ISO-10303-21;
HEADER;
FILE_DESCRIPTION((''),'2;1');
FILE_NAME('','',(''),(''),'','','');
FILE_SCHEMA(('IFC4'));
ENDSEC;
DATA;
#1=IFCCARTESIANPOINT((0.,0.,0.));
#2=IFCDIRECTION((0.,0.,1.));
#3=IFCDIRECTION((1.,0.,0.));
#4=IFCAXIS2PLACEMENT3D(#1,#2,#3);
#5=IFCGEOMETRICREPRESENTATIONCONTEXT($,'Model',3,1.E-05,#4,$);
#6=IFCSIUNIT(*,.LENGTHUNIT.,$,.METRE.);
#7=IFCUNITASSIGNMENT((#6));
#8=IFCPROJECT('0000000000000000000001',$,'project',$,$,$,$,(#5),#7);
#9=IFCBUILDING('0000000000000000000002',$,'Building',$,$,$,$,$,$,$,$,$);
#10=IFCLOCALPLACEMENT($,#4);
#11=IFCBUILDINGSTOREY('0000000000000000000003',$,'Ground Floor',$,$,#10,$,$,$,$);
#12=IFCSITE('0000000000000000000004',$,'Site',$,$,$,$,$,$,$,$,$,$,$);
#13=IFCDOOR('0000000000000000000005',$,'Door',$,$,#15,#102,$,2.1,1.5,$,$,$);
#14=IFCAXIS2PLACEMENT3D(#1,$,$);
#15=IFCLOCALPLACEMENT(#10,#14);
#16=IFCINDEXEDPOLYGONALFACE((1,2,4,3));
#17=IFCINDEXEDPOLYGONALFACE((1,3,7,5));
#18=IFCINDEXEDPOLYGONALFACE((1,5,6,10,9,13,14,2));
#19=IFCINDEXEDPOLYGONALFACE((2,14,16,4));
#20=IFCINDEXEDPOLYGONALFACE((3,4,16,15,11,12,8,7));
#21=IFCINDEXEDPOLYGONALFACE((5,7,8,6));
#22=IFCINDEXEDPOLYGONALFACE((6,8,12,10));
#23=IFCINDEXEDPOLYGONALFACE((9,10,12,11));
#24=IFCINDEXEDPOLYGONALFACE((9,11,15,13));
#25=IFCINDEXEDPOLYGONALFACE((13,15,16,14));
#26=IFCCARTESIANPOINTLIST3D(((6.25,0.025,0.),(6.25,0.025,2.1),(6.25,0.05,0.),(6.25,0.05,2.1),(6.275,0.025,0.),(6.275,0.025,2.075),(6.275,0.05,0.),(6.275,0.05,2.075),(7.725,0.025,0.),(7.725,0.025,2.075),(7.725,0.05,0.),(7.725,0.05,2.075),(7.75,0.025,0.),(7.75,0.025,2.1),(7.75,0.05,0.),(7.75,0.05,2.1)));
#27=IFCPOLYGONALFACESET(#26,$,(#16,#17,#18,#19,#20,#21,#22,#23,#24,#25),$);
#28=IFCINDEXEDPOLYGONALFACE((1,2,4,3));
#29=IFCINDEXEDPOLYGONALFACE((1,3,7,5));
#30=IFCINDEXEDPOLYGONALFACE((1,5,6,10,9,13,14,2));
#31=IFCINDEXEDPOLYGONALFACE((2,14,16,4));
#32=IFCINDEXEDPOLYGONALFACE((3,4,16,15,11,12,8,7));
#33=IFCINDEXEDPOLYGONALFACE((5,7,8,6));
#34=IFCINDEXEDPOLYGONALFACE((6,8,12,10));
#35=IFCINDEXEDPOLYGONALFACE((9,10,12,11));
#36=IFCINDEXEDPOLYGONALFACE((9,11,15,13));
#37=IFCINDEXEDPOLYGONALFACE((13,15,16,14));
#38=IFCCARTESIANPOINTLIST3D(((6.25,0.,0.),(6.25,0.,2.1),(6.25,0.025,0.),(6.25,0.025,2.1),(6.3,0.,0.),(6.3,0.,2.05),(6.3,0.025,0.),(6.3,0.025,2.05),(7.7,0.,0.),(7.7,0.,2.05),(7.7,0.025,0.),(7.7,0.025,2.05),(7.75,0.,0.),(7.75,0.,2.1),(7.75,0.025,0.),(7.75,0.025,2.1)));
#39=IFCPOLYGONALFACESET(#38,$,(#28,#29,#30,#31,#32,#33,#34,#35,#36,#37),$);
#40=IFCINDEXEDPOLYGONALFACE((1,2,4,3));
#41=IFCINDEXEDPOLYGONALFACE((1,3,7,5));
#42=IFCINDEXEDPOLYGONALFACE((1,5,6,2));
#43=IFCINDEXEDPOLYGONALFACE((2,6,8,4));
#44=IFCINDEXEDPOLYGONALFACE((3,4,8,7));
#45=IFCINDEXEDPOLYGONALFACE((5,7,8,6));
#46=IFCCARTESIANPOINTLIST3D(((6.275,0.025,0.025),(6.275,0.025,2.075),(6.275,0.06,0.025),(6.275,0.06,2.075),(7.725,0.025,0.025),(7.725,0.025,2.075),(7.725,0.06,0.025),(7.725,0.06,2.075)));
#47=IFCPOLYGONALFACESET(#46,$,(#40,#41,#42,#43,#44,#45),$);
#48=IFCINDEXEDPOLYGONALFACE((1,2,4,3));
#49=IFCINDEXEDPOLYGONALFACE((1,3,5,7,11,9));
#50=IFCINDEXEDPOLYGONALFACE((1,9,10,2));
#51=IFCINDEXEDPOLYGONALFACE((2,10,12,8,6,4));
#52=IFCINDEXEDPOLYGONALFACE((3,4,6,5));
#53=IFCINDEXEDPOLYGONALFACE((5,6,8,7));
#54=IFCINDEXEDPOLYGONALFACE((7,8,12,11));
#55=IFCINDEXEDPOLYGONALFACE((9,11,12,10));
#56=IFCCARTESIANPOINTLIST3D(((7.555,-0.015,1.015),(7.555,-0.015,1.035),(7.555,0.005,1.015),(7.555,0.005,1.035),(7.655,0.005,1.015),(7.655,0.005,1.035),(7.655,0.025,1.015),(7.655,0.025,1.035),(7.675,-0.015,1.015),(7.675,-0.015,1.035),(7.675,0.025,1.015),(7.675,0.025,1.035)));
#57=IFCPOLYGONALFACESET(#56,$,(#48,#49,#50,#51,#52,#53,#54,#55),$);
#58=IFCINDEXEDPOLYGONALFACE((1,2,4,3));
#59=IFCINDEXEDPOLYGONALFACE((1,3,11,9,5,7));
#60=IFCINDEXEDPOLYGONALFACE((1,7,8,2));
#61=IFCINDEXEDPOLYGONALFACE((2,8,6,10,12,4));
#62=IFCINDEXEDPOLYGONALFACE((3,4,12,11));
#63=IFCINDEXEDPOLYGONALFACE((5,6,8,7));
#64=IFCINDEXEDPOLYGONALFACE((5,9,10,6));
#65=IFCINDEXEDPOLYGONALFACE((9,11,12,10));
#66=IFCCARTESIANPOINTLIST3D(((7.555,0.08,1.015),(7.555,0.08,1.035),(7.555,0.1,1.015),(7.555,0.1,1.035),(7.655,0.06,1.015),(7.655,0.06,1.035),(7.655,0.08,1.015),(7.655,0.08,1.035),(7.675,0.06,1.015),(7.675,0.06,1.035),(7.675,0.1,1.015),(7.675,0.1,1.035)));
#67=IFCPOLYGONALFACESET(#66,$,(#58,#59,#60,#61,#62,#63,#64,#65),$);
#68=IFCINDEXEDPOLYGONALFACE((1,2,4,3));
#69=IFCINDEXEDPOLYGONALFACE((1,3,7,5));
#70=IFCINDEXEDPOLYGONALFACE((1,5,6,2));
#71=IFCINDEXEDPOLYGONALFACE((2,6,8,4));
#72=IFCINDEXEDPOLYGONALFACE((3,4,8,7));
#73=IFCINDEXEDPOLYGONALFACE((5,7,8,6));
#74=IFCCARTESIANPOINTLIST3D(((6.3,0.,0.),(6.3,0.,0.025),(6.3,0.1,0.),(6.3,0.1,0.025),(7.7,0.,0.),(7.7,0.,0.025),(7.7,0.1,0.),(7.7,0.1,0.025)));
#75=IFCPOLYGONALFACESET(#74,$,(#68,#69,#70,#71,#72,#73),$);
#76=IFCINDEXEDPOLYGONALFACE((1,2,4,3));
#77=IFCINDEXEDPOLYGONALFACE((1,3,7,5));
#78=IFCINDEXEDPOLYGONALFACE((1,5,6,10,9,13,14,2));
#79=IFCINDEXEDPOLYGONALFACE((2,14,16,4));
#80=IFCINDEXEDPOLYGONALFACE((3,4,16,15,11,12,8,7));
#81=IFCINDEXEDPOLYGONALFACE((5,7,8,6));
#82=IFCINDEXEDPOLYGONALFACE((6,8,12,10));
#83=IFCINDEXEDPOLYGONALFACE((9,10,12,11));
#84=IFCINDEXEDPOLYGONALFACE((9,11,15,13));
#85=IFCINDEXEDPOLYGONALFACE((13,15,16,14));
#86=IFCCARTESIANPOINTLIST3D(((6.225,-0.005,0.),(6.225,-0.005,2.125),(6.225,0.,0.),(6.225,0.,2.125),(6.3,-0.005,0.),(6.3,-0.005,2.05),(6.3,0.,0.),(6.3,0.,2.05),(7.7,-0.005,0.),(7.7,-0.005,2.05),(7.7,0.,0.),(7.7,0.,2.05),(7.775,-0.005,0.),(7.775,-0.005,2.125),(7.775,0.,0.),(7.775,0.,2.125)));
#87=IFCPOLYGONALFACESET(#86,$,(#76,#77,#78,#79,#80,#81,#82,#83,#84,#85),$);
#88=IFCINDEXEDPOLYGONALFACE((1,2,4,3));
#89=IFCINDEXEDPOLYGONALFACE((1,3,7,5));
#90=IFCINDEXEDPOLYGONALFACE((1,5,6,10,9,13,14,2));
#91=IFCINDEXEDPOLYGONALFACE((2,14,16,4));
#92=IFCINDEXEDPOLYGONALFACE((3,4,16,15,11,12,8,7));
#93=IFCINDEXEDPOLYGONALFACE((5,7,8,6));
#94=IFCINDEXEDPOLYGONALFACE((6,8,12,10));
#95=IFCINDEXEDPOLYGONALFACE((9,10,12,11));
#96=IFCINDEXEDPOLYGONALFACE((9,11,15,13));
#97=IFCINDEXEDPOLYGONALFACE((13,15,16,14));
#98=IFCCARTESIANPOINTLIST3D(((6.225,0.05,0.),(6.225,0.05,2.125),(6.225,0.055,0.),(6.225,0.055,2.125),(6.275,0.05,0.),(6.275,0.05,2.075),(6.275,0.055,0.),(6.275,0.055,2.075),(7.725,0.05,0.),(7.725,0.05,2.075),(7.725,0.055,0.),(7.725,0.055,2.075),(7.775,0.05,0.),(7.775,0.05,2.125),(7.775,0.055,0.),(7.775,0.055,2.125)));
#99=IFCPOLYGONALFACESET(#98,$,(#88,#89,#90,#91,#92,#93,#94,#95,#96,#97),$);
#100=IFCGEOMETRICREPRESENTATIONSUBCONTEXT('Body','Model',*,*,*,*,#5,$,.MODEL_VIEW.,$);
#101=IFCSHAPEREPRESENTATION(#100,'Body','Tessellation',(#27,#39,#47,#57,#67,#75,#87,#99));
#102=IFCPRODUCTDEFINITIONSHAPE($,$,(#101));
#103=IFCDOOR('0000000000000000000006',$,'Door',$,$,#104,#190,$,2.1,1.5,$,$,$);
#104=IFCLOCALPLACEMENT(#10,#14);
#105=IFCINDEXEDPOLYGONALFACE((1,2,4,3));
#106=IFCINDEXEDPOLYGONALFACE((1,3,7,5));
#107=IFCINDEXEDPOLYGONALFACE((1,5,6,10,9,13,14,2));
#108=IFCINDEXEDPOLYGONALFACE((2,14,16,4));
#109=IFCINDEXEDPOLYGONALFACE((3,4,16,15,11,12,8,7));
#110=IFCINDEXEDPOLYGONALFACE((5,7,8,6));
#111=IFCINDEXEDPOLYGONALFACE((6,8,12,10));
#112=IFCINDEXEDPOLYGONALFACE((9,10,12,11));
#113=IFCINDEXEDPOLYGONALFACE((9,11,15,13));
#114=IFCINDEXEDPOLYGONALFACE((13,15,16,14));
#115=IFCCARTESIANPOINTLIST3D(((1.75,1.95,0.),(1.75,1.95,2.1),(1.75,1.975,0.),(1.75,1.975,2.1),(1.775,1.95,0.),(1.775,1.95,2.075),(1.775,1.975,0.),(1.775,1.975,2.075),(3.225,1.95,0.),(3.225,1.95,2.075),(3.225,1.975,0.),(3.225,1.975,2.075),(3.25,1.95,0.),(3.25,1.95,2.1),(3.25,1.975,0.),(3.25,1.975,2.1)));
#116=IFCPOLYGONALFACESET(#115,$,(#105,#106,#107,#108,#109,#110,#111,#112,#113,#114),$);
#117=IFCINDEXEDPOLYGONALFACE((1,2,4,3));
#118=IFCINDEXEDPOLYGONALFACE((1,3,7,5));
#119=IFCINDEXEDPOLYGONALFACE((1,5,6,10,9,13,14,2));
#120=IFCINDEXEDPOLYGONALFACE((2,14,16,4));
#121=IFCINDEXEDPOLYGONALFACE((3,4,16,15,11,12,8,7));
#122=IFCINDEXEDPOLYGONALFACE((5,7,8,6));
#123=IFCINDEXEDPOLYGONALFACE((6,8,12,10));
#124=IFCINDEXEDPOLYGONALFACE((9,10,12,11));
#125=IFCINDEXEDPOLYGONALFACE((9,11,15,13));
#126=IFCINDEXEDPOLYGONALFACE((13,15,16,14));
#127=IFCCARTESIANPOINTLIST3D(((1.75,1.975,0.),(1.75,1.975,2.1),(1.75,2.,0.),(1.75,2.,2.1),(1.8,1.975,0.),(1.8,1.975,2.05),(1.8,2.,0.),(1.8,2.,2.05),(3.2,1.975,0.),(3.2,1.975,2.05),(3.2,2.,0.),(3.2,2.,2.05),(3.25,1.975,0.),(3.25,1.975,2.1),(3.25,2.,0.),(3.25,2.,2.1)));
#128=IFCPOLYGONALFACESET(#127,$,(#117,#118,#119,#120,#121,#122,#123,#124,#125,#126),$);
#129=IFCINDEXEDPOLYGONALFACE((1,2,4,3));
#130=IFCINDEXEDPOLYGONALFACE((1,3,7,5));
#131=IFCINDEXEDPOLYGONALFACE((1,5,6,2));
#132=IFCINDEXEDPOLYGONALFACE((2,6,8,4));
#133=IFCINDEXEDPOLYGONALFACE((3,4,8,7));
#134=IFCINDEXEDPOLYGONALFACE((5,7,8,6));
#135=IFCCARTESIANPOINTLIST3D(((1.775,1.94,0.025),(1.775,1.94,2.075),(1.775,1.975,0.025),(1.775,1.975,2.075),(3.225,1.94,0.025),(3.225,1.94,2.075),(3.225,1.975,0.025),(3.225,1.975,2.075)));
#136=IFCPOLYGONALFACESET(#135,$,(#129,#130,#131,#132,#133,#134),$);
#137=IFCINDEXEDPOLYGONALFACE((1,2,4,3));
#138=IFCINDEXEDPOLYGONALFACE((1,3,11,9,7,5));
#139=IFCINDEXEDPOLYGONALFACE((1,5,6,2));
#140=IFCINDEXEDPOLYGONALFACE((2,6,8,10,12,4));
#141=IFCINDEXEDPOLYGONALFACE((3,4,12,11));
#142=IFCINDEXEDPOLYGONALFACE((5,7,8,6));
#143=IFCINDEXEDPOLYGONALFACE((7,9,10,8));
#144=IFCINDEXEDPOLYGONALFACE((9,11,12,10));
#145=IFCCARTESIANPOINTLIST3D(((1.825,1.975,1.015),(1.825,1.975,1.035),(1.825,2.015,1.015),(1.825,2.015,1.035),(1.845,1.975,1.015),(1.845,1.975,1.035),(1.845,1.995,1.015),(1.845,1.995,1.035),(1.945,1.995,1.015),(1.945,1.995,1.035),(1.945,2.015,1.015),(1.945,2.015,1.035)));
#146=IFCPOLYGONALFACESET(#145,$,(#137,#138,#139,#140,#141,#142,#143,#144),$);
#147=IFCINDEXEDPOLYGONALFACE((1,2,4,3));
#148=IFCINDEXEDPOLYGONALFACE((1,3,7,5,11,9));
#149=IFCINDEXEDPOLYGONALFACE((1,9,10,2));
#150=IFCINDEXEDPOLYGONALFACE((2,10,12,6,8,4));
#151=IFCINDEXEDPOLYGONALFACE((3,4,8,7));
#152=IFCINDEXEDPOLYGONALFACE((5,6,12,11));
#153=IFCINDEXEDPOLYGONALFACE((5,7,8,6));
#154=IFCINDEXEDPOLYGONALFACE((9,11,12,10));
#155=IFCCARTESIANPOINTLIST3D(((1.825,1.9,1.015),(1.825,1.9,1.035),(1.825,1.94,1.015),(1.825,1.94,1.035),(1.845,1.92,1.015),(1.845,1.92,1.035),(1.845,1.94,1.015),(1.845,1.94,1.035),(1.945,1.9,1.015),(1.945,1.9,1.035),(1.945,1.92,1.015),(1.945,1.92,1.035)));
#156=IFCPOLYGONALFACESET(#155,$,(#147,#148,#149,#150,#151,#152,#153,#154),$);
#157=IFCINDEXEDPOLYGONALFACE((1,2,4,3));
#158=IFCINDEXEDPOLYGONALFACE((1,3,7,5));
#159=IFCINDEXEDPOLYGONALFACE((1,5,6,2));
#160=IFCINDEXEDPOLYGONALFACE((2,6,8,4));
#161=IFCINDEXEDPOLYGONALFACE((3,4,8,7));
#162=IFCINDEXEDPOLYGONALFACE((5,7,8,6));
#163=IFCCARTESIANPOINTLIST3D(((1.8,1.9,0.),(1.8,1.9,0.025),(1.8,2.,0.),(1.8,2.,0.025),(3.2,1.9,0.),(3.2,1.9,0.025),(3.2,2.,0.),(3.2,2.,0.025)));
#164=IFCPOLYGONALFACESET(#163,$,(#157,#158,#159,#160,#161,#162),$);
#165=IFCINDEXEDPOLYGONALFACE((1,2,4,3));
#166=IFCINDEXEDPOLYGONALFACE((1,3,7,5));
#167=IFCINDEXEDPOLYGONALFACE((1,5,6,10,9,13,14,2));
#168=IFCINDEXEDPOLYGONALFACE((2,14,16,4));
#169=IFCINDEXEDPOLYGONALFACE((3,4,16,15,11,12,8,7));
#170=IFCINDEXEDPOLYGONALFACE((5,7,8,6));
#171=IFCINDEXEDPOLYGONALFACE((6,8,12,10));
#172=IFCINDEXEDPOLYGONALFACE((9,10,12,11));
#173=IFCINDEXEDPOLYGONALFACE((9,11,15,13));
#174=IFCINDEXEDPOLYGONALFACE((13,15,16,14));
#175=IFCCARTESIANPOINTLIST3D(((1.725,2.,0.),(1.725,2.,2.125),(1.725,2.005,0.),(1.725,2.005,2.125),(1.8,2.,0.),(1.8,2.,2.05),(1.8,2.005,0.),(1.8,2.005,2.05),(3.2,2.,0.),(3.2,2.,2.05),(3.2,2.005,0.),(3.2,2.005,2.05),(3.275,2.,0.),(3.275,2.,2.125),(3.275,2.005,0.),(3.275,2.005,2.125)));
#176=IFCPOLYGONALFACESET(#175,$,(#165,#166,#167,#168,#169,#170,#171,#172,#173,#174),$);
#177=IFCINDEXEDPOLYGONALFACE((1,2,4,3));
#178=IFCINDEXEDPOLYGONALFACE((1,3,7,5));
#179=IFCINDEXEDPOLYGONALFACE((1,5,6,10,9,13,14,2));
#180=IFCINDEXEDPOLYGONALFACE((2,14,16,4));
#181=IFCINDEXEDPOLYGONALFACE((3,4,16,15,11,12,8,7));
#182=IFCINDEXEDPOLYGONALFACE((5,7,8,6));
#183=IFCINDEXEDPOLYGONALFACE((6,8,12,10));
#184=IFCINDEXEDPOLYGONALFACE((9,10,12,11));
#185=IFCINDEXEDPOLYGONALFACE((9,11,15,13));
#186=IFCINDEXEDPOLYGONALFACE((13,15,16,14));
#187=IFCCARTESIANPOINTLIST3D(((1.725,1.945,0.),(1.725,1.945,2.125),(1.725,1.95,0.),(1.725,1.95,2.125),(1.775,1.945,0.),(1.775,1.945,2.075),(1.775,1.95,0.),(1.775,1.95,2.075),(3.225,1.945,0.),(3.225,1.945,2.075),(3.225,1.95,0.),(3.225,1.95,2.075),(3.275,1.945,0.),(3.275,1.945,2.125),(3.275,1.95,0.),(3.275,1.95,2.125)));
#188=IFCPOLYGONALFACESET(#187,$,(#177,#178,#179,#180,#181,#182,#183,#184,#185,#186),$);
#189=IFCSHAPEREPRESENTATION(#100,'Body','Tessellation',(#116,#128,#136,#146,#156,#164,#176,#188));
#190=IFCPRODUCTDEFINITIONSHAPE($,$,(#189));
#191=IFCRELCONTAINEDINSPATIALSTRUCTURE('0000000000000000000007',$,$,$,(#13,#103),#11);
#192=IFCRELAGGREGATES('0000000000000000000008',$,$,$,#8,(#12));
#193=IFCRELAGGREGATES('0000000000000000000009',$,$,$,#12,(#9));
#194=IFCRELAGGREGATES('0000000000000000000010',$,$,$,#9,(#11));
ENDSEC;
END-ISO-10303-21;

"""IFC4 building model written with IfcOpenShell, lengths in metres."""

from ifc_helpers import new_model, si_unit, frame, origin_with_axes, place, context, subcontext, project, spatial, line, indexed_curve, outline, extrude, element, save


model = new_model("IFC4")

# Units and contexts
model_context = context("Model", 3, precision=1e-05, world=origin_with_axes())
body_context = subcontext(model_context, "Body", "Model", "MODEL_VIEW")
ifc_project = project(units=[si_unit("LENGTHUNIT", "METRE")], contexts=[model_context])

# Site, building, storey
site = spatial("IfcSite", under=ifc_project, Name="Site")
building = spatial("IfcBuilding", under=site, Name="Building")
storey_placement = place(None, origin_with_axes())
storey = spatial("IfcBuildingStorey", under=building, at=storey_placement, Name="Ground Floor")

# Doors
door_1_placement = place(storey_placement, frame((6.25, 0.0, 0.0), z_axis=(0.0, 0.0, 1.0), x_axis=(1.0, 0.0, 0.0)))
element("IfcDoor", 1, at=door_1_placement, inside=storey, Name="Door", OverallHeight=2.1, OverallWidth=1.5, context=body_context, shape_type="SweptSolid", body=[
    extrude(outline(indexed_curve([(0.0, 0.0), (0.0, 2.1), (1.5, 2.1), (1.5, 0.0), (1.475, 0.0), (1.475, 2.075), (0.025, 2.075), (0.025, 0.0)], segments=[line(1, 2, 3, 4, 5, 6, 7, 8, 1)])), frame((0.0, 0.025, 0.0), z_axis=(0.0, -1.0, 0.0), x_axis=(1.0, 0.0, 0.0)), (0.0, 0.0, -1.0), 0.025),
    extrude(outline(indexed_curve([(0.0, 0.0), (0.0, 2.1), (1.5, 2.1), (1.5, 0.0), (1.45, 0.0), (1.45, 2.05), (0.05, 2.05), (0.05, 0.0)], segments=[line(1, 2, 3, 4, 5, 6, 7, 8, 1)])), frame((0.0, 0.0, 0.0), z_axis=(0.0, -1.0, 0.0), x_axis=(1.0, 0.0, 0.0)), (0.0, 0.0, -1.0), 0.025),
    extrude(outline(indexed_curve([(0.0, 0.0), (1.45, 0.0), (1.45, 0.035), (0.0, 0.035)], segments=[line(1, 2, 3, 4, 1)])), frame((0.025, 0.025, 0.025), z_axis=(0.0, 0.0, 1.0), x_axis=(1.0, 0.0, 0.0)), (0.0, 0.0, 1.0), 2.05),
    extrude(outline(indexed_curve([(0.0, 0.0), (0.0, -0.04), (-0.12, -0.04), (-0.12, -0.02), (-0.02, -0.02), (-0.02, 0.0)], segments=[line(1, 2, 3, 4, 5, 6, 1)])), frame((1.425, 0.025, 1.015), z_axis=(0.0, 0.0, 1.0), x_axis=(1.0, 0.0, 0.0)), (0.0, 0.0, 1.0), 0.02),
    extrude(outline(indexed_curve([(0.0, 0.0), (0.0, 0.04), (-0.12, 0.04), (-0.12, 0.02), (-0.02, 0.02), (-0.02, 0.0)], segments=[line(1, 2, 3, 4, 5, 6, 1)])), frame((1.425, 0.06, 1.015), z_axis=(0.0, 0.0, 1.0), x_axis=(1.0, 0.0, 0.0)), (0.0, 0.0, 1.0), 0.02),
    extrude(outline(indexed_curve([(0.0, 0.0), (1.4, 0.0), (1.4, 0.1), (0.0, 0.1)], segments=[line(1, 2, 3, 4, 1)])), frame((0.05, 0.0, 0.0), z_axis=(0.0, 0.0, 1.0), x_axis=(1.0, 0.0, 0.0)), (0.0, 0.0, 1.0), 0.025),
    extrude(outline(indexed_curve([(0.0, 0.0), (0.0, 2.125), (1.55, 2.125), (1.55, 0.0), (1.475, 0.0), (1.475, 2.05), (0.075, 2.05), (0.075, 0.0)], segments=[line(1, 2, 3, 4, 5, 6, 7, 8, 1)])), frame((-0.025, -0.005, 0.0), z_axis=(0.0, -1.0, 0.0), x_axis=(1.0, 0.0, 0.0)), (0.0, 0.0, -1.0), 0.005),
    extrude(outline(indexed_curve([(0.0, 0.0), (0.0, 2.125), (1.55, 2.125), (1.55, 0.0), (1.5, 0.0), (1.5, 2.075), (0.05, 2.075), (0.05, 0.0)], segments=[line(1, 2, 3, 4, 5, 6, 7, 8, 1)])), frame((-0.025, 0.05, 0.0), z_axis=(0.0, -1.0, 0.0), x_axis=(1.0, 0.0, 0.0)), (0.0, 0.0, -1.0), 0.005),
])
door_2_placement = place(storey_placement, frame((3.25, 2.0, 0.0), z_axis=(0.0, 0.0, 1.0), x_axis=(-1.0, 0.0, 0.0)))
element("IfcDoor", 2, at=door_2_placement, inside=storey, Name="Door", OverallHeight=2.1, OverallWidth=1.5, context=body_context, shape_type="SweptSolid", body=[
    extrude(outline(indexed_curve([(0.0, 0.0), (0.0, 2.1), (1.5, 2.1), (1.5, 0.0), (1.475, 0.0), (1.475, 2.075), (0.025, 2.075), (0.025, 0.0)], segments=[line(1, 2, 3, 4, 5, 6, 7, 8, 1)])), frame((0.0, 0.025, 0.0), z_axis=(0.0, -1.0, 0.0), x_axis=(1.0, 0.0, 0.0)), (0.0, 0.0, -1.0), 0.025),
    extrude(outline(indexed_curve([(0.0, 0.0), (0.0, 2.1), (1.5, 2.1), (1.5, 0.0), (1.45, 0.0), (1.45, 2.05), (0.05, 2.05), (0.05, 0.0)], segments=[line(1, 2, 3, 4, 5, 6, 7, 8, 1)])), frame((0.0, 0.0, 0.0), z_axis=(0.0, -1.0, 0.0), x_axis=(1.0, 0.0, 0.0)), (0.0, 0.0, -1.0), 0.025),
    extrude(outline(indexed_curve([(0.0, 0.0), (1.45, 0.0), (1.45, 0.035), (0.0, 0.035)], segments=[line(1, 2, 3, 4, 1)])), frame((0.025, 0.025, 0.025), z_axis=(0.0, 0.0, 1.0), x_axis=(1.0, 0.0, 0.0)), (0.0, 0.0, 1.0), 2.05),
    extrude(outline(indexed_curve([(0.0, 0.0), (0.0, -0.04), (-0.12, -0.04), (-0.12, -0.02), (-0.02, -0.02), (-0.02, 0.0)], segments=[line(1, 2, 3, 4, 5, 6, 1)])), frame((1.425, 0.025, 1.015), z_axis=(0.0, 0.0, 1.0), x_axis=(1.0, 0.0, 0.0)), (0.0, 0.0, 1.0), 0.02),
    extrude(outline(indexed_curve([(0.0, 0.0), (0.0, 0.04), (-0.12, 0.04), (-0.12, 0.02), (-0.02, 0.02), (-0.02, 0.0)], segments=[line(1, 2, 3, 4, 5, 6, 1)])), frame((1.425, 0.06, 1.015), z_axis=(0.0, 0.0, 1.0), x_axis=(1.0, 0.0, 0.0)), (0.0, 0.0, 1.0), 0.02),
    extrude(outline(indexed_curve([(0.0, 0.0), (1.4, 0.0), (1.4, 0.1), (0.0, 0.1)], segments=[line(1, 2, 3, 4, 1)])), frame((0.05, 0.0, 0.0), z_axis=(0.0, 0.0, 1.0), x_axis=(1.0, 0.0, 0.0)), (0.0, 0.0, 1.0), 0.025),
    extrude(outline(indexed_curve([(0.0, 0.0), (0.0, 2.125), (1.55, 2.125), (1.55, 0.0), (1.475, 0.0), (1.475, 2.05), (0.075, 2.05), (0.075, 0.0)], segments=[line(1, 2, 3, 4, 5, 6, 7, 8, 1)])), frame((-0.025, -0.005, 0.0), z_axis=(0.0, -1.0, 0.0), x_axis=(1.0, 0.0, 0.0)), (0.0, 0.0, -1.0), 0.005),
    extrude(outline(indexed_curve([(0.0, 0.0), (0.0, 2.125), (1.55, 2.125), (1.55, 0.0), (1.5, 0.0), (1.5, 2.075), (0.05, 2.075), (0.05, 0.0)], segments=[line(1, 2, 3, 4, 5, 6, 7, 8, 1)])), frame((-0.025, 0.05, 0.0), z_axis=(0.0, -1.0, 0.0), x_axis=(1.0, 0.0, 0.0)), (0.0, 0.0, -1.0), 0.005),
])

save(model, "model.ifc")
